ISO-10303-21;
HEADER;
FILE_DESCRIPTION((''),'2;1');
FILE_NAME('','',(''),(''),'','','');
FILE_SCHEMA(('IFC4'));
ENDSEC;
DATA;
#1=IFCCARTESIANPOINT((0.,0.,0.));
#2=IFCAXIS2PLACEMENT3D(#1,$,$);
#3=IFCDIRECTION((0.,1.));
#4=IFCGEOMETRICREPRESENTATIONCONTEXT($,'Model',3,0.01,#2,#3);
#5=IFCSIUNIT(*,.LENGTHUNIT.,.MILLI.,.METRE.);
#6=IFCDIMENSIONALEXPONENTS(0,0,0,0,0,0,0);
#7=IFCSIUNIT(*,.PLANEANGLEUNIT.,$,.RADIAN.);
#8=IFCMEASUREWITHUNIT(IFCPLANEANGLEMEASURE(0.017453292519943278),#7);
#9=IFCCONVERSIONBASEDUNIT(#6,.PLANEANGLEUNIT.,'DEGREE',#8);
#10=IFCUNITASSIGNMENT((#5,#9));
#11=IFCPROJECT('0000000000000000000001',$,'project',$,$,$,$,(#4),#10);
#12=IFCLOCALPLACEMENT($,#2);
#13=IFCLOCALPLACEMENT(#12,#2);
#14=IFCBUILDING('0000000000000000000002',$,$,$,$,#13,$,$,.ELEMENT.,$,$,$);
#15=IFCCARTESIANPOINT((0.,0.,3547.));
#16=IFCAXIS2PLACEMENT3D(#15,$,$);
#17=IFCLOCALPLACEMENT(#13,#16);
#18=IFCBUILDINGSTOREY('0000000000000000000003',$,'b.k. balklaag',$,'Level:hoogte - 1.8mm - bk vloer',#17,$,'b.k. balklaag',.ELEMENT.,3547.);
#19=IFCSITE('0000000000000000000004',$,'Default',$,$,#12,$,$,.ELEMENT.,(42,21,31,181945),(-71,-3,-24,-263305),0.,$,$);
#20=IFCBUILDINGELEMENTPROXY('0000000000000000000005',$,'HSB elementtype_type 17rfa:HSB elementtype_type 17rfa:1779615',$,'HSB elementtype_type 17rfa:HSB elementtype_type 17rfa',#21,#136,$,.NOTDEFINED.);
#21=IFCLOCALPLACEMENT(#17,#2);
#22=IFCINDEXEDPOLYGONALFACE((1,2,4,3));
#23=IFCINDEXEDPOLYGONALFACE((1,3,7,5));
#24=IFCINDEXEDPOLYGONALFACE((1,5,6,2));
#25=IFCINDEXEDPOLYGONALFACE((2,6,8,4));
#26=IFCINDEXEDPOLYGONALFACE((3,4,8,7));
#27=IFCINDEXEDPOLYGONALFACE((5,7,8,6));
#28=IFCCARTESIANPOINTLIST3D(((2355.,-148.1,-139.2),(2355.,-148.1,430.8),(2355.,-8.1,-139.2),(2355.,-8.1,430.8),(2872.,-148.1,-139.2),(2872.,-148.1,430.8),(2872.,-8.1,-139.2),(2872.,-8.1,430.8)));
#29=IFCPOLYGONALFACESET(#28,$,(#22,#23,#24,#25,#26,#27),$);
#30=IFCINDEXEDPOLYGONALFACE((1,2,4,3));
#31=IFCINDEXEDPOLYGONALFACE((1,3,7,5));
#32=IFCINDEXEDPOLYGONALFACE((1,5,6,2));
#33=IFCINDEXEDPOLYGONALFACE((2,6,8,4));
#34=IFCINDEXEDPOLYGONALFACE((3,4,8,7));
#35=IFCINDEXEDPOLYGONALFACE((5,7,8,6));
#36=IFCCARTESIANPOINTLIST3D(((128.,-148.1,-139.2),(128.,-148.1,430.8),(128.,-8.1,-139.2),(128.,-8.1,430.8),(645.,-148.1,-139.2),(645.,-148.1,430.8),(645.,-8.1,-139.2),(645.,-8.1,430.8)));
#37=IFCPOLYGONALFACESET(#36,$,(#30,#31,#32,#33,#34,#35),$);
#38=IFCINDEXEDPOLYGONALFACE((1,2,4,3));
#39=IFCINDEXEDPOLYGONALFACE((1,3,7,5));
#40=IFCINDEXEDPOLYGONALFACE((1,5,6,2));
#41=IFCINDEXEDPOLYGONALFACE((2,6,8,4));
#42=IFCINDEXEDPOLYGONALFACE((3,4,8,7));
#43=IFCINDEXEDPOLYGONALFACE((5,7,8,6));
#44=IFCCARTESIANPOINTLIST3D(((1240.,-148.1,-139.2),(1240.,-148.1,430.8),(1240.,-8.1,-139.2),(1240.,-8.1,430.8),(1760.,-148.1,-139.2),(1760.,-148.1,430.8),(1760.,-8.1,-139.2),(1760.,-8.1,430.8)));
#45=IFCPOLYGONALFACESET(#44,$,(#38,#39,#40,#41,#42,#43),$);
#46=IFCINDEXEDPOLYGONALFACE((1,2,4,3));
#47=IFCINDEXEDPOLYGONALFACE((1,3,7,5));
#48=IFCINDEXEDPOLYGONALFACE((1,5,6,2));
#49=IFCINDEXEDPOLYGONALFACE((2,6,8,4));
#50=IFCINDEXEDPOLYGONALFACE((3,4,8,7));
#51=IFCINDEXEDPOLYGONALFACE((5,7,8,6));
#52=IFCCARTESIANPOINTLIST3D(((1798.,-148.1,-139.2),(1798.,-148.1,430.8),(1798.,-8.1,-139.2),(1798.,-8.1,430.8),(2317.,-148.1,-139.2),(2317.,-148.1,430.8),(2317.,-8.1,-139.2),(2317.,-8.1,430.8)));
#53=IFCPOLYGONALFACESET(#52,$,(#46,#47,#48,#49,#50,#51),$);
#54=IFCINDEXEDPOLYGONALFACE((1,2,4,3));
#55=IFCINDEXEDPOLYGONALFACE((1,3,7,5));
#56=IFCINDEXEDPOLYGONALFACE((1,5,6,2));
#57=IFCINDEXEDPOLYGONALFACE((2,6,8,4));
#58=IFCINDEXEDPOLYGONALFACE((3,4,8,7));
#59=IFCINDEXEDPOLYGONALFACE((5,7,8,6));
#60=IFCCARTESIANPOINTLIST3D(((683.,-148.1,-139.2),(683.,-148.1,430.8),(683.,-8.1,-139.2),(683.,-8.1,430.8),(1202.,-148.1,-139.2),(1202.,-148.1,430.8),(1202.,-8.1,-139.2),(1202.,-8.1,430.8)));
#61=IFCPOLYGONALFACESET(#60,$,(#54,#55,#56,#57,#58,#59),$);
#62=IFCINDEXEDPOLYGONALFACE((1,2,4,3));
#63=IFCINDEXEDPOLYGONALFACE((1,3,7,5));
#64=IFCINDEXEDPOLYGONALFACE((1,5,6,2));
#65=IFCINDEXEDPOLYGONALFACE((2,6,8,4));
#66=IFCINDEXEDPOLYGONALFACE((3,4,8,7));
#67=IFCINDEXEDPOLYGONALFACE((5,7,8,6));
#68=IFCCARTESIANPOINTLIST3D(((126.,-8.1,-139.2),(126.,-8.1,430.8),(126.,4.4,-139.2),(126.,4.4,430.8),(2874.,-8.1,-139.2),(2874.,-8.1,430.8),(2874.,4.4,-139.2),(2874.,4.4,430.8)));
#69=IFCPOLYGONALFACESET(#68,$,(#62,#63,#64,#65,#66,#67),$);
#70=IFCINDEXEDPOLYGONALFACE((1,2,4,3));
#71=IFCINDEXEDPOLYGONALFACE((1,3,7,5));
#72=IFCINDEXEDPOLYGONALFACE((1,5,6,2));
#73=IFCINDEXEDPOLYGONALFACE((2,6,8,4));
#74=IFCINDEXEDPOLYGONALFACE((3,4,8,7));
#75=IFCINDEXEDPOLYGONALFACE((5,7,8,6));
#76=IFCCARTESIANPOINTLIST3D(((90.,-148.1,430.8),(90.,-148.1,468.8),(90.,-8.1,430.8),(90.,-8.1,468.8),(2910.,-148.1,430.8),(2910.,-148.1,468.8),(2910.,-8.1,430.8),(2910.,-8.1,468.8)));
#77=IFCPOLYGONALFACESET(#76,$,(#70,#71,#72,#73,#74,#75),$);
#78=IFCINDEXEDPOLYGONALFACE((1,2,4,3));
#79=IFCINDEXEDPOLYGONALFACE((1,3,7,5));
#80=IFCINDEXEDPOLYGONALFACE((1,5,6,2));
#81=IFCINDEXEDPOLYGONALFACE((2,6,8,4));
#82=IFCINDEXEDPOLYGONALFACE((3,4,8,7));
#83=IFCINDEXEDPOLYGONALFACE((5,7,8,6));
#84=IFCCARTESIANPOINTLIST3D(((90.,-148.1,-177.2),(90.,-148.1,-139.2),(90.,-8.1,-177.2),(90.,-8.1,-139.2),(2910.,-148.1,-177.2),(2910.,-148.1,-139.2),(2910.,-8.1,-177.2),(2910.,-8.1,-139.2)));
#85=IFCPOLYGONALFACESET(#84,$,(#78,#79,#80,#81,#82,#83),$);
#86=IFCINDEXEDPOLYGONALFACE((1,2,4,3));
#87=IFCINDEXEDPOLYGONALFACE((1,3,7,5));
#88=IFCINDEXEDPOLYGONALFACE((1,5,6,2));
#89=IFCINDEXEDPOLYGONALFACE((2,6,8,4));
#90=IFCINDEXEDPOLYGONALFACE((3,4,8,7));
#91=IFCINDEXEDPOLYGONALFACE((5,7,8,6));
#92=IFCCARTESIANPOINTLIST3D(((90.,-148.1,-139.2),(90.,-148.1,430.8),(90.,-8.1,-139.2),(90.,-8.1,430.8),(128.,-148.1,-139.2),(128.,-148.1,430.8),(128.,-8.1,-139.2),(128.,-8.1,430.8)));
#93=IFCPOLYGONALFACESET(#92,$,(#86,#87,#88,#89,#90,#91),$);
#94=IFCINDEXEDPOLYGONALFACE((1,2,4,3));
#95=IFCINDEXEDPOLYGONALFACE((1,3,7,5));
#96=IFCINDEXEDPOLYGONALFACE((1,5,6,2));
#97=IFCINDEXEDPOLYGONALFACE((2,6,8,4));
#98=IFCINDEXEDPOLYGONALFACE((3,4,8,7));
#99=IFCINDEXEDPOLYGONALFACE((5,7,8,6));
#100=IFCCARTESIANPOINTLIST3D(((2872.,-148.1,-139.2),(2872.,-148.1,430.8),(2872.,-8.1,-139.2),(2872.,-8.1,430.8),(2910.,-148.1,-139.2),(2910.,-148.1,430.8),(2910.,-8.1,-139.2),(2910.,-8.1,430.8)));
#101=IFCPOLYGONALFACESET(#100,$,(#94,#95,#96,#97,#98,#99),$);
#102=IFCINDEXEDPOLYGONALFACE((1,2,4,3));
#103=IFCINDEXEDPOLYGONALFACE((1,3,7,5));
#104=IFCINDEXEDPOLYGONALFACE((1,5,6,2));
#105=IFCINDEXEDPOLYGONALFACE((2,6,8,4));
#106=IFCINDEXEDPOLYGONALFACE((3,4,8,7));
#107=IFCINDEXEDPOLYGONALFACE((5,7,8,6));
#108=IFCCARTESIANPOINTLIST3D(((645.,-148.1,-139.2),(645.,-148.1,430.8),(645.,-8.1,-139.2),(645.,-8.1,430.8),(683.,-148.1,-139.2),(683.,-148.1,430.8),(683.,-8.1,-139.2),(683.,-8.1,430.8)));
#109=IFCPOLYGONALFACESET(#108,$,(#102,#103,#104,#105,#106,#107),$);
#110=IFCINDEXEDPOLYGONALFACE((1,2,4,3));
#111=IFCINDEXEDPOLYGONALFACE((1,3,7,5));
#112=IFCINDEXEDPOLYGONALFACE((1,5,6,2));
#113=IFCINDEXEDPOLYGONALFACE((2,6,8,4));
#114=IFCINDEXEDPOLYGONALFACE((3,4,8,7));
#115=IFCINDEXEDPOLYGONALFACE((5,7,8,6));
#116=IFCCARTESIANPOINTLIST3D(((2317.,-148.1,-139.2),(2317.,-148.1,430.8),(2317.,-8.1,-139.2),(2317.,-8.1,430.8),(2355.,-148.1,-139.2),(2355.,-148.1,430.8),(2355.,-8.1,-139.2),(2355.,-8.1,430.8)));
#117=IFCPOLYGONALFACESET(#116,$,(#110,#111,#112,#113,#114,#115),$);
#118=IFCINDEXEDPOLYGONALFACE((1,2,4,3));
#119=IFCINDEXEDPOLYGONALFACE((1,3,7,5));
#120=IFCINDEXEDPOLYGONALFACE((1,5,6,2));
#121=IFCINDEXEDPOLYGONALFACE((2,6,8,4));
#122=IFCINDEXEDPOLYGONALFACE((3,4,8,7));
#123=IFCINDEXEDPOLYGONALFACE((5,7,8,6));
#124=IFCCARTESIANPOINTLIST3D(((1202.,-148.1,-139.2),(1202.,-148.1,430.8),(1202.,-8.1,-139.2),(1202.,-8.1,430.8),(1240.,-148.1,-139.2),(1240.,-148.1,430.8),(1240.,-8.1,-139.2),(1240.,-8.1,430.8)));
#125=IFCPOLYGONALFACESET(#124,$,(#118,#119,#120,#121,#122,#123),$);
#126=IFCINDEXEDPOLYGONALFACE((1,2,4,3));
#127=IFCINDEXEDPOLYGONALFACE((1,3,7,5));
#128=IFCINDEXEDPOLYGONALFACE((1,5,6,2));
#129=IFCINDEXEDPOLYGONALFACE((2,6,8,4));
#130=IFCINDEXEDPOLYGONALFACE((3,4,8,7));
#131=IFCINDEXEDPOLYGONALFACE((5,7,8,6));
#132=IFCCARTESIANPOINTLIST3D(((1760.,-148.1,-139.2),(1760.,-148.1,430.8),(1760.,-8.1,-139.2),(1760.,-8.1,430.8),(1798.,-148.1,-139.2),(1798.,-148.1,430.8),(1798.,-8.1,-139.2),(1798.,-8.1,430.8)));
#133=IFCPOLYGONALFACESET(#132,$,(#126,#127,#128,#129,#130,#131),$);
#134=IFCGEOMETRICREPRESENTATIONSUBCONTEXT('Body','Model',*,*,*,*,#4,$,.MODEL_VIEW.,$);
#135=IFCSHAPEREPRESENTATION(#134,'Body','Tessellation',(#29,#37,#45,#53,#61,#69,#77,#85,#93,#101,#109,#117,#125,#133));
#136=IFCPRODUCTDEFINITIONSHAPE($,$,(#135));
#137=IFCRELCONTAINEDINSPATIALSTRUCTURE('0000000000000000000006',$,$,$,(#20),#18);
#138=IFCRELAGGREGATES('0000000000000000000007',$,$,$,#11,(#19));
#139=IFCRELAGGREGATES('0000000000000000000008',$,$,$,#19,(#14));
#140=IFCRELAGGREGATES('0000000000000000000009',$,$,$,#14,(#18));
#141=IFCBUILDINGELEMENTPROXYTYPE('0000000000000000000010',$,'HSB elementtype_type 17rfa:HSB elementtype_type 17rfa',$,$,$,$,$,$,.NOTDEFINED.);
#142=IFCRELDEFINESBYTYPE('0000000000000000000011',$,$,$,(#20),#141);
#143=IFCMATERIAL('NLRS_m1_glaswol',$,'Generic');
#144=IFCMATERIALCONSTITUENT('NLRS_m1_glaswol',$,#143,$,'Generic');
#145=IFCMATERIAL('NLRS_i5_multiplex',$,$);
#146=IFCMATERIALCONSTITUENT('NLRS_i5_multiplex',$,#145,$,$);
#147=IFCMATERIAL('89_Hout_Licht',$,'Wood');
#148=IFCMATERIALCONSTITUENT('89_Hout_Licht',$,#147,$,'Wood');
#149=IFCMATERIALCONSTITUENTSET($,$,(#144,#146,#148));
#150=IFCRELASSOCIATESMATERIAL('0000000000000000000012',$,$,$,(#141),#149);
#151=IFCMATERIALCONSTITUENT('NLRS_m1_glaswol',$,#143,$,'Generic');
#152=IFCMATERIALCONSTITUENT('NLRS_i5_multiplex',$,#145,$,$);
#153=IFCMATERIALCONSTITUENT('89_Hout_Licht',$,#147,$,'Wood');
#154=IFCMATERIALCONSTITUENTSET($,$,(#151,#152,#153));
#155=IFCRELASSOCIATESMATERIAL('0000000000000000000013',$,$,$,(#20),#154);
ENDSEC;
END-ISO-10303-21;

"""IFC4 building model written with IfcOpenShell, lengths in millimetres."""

from ifc_helpers import new_model, entity, si_unit, converted_unit, direction, frame, origin, place, context, subcontext, project, spatial, indexed_curve, outline, extrude, source, transform, mapped, material, constituent, constituent_set, type_object, type_shapes, element, save


model = new_model("IFC4")

# Units and contexts
model_context = context("Model", 3, precision=0.01, world=origin(), true_north=direction((0.0, 1.0)))
body_context = subcontext(model_context, "Body", "Model", "MODEL_VIEW")
ifc_project = project(units=[si_unit("LENGTHUNIT", "METRE", prefix="MILLI"), converted_unit("PLANEANGLEUNIT", "DEGREE", entity("IfcPlaneAngleMeasure", 0.017453292519943278), si_unit("PLANEANGLEUNIT", "RADIAN"), dimensions=[0, 0, 0, 0, 0, 0, 0])], contexts=[model_context])

# Site, building, storey
site_placement = place(None, origin())
site = spatial("IfcSite", under=ifc_project, at=site_placement, Name="Default", CompositionType="ELEMENT", RefLatitude=(42, 21, 31, 181945), RefLongitude=(-71, -3, -24, -263305), RefElevation=0.0)
building_placement = place(site_placement, origin())
building = spatial("IfcBuilding", under=site, at=building_placement, CompositionType="ELEMENT")
storey_placement = place(building_placement, frame((0.0, 0.0, 3547.0)))
storey = spatial("IfcBuildingStorey", under=building, at=storey_placement, Name="b.k. balklaag", ObjectType="Level:hoogte - 1.8mm - bk vloer", LongName="b.k. balklaag", CompositionType="ELEMENT", Elevation=3547.0)

# Shared definitions
ifc_material_1 = material(Name="89_Hout_Licht", Category="Wood")

# Building element proxy
ifc_material_2 = material(Name="NLRS_m1_glaswol", Category="Generic")
ifc_material_3 = material(Name="NLRS_i5_multiplex")
ifc_constituent_1 = constituent(ifc_material_2, Name="NLRS_m1_glaswol", Category="Generic")
ifc_constituent_2 = constituent(ifc_material_3, Name="NLRS_i5_multiplex")
ifc_constituent_3 = constituent(ifc_material_1, Name="89_Hout_Licht", Category="Wood")
ifc_constituent_set_1 = constituent_set(constituents=[ifc_constituent_1, ifc_constituent_2, ifc_constituent_3])
ifc_constituent_4 = constituent(ifc_material_2, Name="NLRS_m1_glaswol", Category="Generic")
ifc_constituent_5 = constituent(ifc_material_3, Name="NLRS_i5_multiplex")
ifc_constituent_6 = constituent(ifc_material_1, Name="89_Hout_Licht", Category="Wood")
ifc_constituent_set_2 = constituent_set(constituents=[ifc_constituent_4, ifc_constituent_5, ifc_constituent_6])
building_element_proxy_type_1 = type_object("IfcBuildingElementProxyType", Name="HSB elementtype_type 17rfa:HSB elementtype_type 17rfa", PredefinedType="NOTDEFINED", material=ifc_constituent_set_2)
shared_shape_1 = source(origin(), body_context, "Body", "SweptSolid", [
    extrude(outline(indexed_curve([(-258.5, -70.0), (258.5, -70.0), (258.5, 70.0), (-258.5, 70.0), (-258.5, -70.0)], self_intersect=False)), frame((-1149.5, 70.0, 38.0), z_axis=(0.0, 0.0, 1.0), x_axis=(-1.0, 0.0, 0.0)), (0.0, 0.0, 1.0), 570.0),
    extrude(outline(indexed_curve([(-258.5, -70.0), (258.5, -70.0), (258.5, 70.0), (-258.5, 70.0), (-258.5, -70.0)], self_intersect=False)), frame((1077.5, 70.0, 38.0), z_axis=(0.0, 0.0, 1.0), x_axis=(-1.0, 0.0, 0.0)), (0.0, 0.0, 1.0), 570.0),
    extrude(outline(indexed_curve([(-260.0, -70.0), (260.0, -70.0), (260.0, 70.0), (-260.0, 70.0), (-260.0, -70.0)], self_intersect=False)), frame((-36.0, 70.0, 38.0), z_axis=(0.0, 0.0, 1.0), x_axis=(-1.0, 0.0, 0.0)), (0.0, 0.0, 1.0), 570.0),
    extrude(outline(indexed_curve([(-259.5, -70.0), (259.5, -70.0), (259.5, 70.0), (-259.5, 70.0), (-259.5, -70.0)], self_intersect=False)), frame((-593.5, 70.0, 38.0), z_axis=(0.0, 0.0, 1.0), x_axis=(-1.0, 0.0, 0.0)), (0.0, 0.0, 1.0), 570.0),
    extrude(outline(indexed_curve([(-259.5, -70.0), (259.5, -70.0), (259.5, 70.0), (-259.5, 70.0), (-259.5, -70.0)], self_intersect=False)), frame((521.5, 70.0, 38.0), z_axis=(0.0, 0.0, 1.0), x_axis=(-1.0, 0.0, 0.0)), (0.0, 0.0, 1.0), 570.0),
    extrude(outline(indexed_curve([(-1374.0, -6.2), (1374.0, -6.2), (1374.0, 6.2), (-1374.0, 6.2), (-1374.0, -6.2)], self_intersect=False)), frame((-36.0, -6.2, 38.0), z_axis=(0.0, 0.0, 1.0), x_axis=(-1.0, 0.0, 0.0)), (0.0, 0.0, 1.0), 570.0),
    extrude(outline(indexed_curve([(-1410.0, -70.0), (1410.0, -70.0), (1410.0, 70.0), (-1410.0, 70.0), (-1410.0, -70.0)], self_intersect=False)), frame((-36.0, 70.0, 608.0), z_axis=(0.0, 0.0, 1.0), x_axis=(-1.0, 0.0, 0.0)), (0.0, 0.0, 1.0), 38.0),
    extrude(outline(indexed_curve([(-1410.0, -70.0), (1410.0, -70.0), (1410.0, 70.0), (-1410.0, 70.0), (-1410.0, -70.0)], self_intersect=False)), frame((-36.0, 70.0, 0.0), z_axis=(0.0, 0.0, 1.0), x_axis=(-1.0, 0.0, 0.0)), (0.0, 0.0, 1.0), 38.0),
    extrude(outline(indexed_curve([(-19.0, -70.0), (19.0, -70.0), (19.0, 70.0), (-19.0, 70.0), (-19.0, -70.0)], self_intersect=False)), frame((1355.0, 70.0, 38.0), z_axis=(0.0, 0.0, 1.0), x_axis=(-1.0, 0.0, 0.0)), (0.0, 0.0, 1.0), 570.0),
    extrude(outline(indexed_curve([(-19.0, -70.0), (19.0, -70.0), (19.0, 70.0), (-19.0, 70.0), (-19.0, -70.0)], self_intersect=False)), frame((-1427.0, 70.0, 38.0), z_axis=(0.0, 0.0, 1.0), x_axis=(-1.0, 0.0, 0.0)), (0.0, 0.0, 1.0), 570.0),
    extrude(outline(indexed_curve([(-19.0, -70.0), (19.0, -70.0), (19.0, 70.0), (-19.0, 70.0), (-19.0, -70.0)], self_intersect=False)), frame((800.0, 70.0, 38.0), z_axis=(0.0, 0.0, 1.0), x_axis=(-1.0, 0.0, 0.0)), (0.0, 0.0, 1.0), 570.0),
    extrude(outline(indexed_curve([(-19.0, -70.0), (19.0, -70.0), (19.0, 70.0), (-19.0, 70.0), (-19.0, -70.0)], self_intersect=False)), frame((-872.0, 70.0, 38.0), z_axis=(0.0, 0.0, 1.0), x_axis=(-1.0, 0.0, 0.0)), (0.0, 0.0, 1.0), 570.0),
    extrude(outline(indexed_curve([(-19.0, -70.0), (19.0, -70.0), (19.0, 70.0), (-19.0, 70.0), (-19.0, -70.0)], self_intersect=False)), frame((243.0, 70.0, 38.0), z_axis=(0.0, 0.0, 1.0), x_axis=(-1.0, 0.0, 0.0)), (0.0, 0.0, 1.0), 570.0),
    extrude(outline(indexed_curve([(-19.0, -70.0), (19.0, -70.0), (19.0, 70.0), (-19.0, 70.0), (-19.0, -70.0)], self_intersect=False)), frame((-315.0, 70.0, 38.0), z_axis=(0.0, 0.0, 1.0), x_axis=(-1.0, 0.0, 0.0)), (0.0, 0.0, 1.0), 570.0),
])
type_shapes(building_element_proxy_type_1, [shared_shape_1])
proxy_1_placement = place(storey_placement, frame((1464.0, -8.1, -177.2), z_axis=(0.0, 0.0, 1.0), x_axis=(-1.0, 0.0, 0.0)))
element("IfcBuildingElementProxy", 1, at=proxy_1_placement, inside=storey, type_object=building_element_proxy_type_1, material=ifc_constituent_set_1, Name="HSB elementtype_type 17rfa:HSB elementtype_type 17rfa:1779615", ObjectType="HSB elementtype_type 17rfa:HSB elementtype_type 17rfa", PredefinedType="NOTDEFINED", context=body_context, shape_type="MappedRepresentation", body=[
    mapped(shared_shape_1, transform((0.0, 0.0, 0.0), scale=1.0)),
])

save(model, "model.ifc")
